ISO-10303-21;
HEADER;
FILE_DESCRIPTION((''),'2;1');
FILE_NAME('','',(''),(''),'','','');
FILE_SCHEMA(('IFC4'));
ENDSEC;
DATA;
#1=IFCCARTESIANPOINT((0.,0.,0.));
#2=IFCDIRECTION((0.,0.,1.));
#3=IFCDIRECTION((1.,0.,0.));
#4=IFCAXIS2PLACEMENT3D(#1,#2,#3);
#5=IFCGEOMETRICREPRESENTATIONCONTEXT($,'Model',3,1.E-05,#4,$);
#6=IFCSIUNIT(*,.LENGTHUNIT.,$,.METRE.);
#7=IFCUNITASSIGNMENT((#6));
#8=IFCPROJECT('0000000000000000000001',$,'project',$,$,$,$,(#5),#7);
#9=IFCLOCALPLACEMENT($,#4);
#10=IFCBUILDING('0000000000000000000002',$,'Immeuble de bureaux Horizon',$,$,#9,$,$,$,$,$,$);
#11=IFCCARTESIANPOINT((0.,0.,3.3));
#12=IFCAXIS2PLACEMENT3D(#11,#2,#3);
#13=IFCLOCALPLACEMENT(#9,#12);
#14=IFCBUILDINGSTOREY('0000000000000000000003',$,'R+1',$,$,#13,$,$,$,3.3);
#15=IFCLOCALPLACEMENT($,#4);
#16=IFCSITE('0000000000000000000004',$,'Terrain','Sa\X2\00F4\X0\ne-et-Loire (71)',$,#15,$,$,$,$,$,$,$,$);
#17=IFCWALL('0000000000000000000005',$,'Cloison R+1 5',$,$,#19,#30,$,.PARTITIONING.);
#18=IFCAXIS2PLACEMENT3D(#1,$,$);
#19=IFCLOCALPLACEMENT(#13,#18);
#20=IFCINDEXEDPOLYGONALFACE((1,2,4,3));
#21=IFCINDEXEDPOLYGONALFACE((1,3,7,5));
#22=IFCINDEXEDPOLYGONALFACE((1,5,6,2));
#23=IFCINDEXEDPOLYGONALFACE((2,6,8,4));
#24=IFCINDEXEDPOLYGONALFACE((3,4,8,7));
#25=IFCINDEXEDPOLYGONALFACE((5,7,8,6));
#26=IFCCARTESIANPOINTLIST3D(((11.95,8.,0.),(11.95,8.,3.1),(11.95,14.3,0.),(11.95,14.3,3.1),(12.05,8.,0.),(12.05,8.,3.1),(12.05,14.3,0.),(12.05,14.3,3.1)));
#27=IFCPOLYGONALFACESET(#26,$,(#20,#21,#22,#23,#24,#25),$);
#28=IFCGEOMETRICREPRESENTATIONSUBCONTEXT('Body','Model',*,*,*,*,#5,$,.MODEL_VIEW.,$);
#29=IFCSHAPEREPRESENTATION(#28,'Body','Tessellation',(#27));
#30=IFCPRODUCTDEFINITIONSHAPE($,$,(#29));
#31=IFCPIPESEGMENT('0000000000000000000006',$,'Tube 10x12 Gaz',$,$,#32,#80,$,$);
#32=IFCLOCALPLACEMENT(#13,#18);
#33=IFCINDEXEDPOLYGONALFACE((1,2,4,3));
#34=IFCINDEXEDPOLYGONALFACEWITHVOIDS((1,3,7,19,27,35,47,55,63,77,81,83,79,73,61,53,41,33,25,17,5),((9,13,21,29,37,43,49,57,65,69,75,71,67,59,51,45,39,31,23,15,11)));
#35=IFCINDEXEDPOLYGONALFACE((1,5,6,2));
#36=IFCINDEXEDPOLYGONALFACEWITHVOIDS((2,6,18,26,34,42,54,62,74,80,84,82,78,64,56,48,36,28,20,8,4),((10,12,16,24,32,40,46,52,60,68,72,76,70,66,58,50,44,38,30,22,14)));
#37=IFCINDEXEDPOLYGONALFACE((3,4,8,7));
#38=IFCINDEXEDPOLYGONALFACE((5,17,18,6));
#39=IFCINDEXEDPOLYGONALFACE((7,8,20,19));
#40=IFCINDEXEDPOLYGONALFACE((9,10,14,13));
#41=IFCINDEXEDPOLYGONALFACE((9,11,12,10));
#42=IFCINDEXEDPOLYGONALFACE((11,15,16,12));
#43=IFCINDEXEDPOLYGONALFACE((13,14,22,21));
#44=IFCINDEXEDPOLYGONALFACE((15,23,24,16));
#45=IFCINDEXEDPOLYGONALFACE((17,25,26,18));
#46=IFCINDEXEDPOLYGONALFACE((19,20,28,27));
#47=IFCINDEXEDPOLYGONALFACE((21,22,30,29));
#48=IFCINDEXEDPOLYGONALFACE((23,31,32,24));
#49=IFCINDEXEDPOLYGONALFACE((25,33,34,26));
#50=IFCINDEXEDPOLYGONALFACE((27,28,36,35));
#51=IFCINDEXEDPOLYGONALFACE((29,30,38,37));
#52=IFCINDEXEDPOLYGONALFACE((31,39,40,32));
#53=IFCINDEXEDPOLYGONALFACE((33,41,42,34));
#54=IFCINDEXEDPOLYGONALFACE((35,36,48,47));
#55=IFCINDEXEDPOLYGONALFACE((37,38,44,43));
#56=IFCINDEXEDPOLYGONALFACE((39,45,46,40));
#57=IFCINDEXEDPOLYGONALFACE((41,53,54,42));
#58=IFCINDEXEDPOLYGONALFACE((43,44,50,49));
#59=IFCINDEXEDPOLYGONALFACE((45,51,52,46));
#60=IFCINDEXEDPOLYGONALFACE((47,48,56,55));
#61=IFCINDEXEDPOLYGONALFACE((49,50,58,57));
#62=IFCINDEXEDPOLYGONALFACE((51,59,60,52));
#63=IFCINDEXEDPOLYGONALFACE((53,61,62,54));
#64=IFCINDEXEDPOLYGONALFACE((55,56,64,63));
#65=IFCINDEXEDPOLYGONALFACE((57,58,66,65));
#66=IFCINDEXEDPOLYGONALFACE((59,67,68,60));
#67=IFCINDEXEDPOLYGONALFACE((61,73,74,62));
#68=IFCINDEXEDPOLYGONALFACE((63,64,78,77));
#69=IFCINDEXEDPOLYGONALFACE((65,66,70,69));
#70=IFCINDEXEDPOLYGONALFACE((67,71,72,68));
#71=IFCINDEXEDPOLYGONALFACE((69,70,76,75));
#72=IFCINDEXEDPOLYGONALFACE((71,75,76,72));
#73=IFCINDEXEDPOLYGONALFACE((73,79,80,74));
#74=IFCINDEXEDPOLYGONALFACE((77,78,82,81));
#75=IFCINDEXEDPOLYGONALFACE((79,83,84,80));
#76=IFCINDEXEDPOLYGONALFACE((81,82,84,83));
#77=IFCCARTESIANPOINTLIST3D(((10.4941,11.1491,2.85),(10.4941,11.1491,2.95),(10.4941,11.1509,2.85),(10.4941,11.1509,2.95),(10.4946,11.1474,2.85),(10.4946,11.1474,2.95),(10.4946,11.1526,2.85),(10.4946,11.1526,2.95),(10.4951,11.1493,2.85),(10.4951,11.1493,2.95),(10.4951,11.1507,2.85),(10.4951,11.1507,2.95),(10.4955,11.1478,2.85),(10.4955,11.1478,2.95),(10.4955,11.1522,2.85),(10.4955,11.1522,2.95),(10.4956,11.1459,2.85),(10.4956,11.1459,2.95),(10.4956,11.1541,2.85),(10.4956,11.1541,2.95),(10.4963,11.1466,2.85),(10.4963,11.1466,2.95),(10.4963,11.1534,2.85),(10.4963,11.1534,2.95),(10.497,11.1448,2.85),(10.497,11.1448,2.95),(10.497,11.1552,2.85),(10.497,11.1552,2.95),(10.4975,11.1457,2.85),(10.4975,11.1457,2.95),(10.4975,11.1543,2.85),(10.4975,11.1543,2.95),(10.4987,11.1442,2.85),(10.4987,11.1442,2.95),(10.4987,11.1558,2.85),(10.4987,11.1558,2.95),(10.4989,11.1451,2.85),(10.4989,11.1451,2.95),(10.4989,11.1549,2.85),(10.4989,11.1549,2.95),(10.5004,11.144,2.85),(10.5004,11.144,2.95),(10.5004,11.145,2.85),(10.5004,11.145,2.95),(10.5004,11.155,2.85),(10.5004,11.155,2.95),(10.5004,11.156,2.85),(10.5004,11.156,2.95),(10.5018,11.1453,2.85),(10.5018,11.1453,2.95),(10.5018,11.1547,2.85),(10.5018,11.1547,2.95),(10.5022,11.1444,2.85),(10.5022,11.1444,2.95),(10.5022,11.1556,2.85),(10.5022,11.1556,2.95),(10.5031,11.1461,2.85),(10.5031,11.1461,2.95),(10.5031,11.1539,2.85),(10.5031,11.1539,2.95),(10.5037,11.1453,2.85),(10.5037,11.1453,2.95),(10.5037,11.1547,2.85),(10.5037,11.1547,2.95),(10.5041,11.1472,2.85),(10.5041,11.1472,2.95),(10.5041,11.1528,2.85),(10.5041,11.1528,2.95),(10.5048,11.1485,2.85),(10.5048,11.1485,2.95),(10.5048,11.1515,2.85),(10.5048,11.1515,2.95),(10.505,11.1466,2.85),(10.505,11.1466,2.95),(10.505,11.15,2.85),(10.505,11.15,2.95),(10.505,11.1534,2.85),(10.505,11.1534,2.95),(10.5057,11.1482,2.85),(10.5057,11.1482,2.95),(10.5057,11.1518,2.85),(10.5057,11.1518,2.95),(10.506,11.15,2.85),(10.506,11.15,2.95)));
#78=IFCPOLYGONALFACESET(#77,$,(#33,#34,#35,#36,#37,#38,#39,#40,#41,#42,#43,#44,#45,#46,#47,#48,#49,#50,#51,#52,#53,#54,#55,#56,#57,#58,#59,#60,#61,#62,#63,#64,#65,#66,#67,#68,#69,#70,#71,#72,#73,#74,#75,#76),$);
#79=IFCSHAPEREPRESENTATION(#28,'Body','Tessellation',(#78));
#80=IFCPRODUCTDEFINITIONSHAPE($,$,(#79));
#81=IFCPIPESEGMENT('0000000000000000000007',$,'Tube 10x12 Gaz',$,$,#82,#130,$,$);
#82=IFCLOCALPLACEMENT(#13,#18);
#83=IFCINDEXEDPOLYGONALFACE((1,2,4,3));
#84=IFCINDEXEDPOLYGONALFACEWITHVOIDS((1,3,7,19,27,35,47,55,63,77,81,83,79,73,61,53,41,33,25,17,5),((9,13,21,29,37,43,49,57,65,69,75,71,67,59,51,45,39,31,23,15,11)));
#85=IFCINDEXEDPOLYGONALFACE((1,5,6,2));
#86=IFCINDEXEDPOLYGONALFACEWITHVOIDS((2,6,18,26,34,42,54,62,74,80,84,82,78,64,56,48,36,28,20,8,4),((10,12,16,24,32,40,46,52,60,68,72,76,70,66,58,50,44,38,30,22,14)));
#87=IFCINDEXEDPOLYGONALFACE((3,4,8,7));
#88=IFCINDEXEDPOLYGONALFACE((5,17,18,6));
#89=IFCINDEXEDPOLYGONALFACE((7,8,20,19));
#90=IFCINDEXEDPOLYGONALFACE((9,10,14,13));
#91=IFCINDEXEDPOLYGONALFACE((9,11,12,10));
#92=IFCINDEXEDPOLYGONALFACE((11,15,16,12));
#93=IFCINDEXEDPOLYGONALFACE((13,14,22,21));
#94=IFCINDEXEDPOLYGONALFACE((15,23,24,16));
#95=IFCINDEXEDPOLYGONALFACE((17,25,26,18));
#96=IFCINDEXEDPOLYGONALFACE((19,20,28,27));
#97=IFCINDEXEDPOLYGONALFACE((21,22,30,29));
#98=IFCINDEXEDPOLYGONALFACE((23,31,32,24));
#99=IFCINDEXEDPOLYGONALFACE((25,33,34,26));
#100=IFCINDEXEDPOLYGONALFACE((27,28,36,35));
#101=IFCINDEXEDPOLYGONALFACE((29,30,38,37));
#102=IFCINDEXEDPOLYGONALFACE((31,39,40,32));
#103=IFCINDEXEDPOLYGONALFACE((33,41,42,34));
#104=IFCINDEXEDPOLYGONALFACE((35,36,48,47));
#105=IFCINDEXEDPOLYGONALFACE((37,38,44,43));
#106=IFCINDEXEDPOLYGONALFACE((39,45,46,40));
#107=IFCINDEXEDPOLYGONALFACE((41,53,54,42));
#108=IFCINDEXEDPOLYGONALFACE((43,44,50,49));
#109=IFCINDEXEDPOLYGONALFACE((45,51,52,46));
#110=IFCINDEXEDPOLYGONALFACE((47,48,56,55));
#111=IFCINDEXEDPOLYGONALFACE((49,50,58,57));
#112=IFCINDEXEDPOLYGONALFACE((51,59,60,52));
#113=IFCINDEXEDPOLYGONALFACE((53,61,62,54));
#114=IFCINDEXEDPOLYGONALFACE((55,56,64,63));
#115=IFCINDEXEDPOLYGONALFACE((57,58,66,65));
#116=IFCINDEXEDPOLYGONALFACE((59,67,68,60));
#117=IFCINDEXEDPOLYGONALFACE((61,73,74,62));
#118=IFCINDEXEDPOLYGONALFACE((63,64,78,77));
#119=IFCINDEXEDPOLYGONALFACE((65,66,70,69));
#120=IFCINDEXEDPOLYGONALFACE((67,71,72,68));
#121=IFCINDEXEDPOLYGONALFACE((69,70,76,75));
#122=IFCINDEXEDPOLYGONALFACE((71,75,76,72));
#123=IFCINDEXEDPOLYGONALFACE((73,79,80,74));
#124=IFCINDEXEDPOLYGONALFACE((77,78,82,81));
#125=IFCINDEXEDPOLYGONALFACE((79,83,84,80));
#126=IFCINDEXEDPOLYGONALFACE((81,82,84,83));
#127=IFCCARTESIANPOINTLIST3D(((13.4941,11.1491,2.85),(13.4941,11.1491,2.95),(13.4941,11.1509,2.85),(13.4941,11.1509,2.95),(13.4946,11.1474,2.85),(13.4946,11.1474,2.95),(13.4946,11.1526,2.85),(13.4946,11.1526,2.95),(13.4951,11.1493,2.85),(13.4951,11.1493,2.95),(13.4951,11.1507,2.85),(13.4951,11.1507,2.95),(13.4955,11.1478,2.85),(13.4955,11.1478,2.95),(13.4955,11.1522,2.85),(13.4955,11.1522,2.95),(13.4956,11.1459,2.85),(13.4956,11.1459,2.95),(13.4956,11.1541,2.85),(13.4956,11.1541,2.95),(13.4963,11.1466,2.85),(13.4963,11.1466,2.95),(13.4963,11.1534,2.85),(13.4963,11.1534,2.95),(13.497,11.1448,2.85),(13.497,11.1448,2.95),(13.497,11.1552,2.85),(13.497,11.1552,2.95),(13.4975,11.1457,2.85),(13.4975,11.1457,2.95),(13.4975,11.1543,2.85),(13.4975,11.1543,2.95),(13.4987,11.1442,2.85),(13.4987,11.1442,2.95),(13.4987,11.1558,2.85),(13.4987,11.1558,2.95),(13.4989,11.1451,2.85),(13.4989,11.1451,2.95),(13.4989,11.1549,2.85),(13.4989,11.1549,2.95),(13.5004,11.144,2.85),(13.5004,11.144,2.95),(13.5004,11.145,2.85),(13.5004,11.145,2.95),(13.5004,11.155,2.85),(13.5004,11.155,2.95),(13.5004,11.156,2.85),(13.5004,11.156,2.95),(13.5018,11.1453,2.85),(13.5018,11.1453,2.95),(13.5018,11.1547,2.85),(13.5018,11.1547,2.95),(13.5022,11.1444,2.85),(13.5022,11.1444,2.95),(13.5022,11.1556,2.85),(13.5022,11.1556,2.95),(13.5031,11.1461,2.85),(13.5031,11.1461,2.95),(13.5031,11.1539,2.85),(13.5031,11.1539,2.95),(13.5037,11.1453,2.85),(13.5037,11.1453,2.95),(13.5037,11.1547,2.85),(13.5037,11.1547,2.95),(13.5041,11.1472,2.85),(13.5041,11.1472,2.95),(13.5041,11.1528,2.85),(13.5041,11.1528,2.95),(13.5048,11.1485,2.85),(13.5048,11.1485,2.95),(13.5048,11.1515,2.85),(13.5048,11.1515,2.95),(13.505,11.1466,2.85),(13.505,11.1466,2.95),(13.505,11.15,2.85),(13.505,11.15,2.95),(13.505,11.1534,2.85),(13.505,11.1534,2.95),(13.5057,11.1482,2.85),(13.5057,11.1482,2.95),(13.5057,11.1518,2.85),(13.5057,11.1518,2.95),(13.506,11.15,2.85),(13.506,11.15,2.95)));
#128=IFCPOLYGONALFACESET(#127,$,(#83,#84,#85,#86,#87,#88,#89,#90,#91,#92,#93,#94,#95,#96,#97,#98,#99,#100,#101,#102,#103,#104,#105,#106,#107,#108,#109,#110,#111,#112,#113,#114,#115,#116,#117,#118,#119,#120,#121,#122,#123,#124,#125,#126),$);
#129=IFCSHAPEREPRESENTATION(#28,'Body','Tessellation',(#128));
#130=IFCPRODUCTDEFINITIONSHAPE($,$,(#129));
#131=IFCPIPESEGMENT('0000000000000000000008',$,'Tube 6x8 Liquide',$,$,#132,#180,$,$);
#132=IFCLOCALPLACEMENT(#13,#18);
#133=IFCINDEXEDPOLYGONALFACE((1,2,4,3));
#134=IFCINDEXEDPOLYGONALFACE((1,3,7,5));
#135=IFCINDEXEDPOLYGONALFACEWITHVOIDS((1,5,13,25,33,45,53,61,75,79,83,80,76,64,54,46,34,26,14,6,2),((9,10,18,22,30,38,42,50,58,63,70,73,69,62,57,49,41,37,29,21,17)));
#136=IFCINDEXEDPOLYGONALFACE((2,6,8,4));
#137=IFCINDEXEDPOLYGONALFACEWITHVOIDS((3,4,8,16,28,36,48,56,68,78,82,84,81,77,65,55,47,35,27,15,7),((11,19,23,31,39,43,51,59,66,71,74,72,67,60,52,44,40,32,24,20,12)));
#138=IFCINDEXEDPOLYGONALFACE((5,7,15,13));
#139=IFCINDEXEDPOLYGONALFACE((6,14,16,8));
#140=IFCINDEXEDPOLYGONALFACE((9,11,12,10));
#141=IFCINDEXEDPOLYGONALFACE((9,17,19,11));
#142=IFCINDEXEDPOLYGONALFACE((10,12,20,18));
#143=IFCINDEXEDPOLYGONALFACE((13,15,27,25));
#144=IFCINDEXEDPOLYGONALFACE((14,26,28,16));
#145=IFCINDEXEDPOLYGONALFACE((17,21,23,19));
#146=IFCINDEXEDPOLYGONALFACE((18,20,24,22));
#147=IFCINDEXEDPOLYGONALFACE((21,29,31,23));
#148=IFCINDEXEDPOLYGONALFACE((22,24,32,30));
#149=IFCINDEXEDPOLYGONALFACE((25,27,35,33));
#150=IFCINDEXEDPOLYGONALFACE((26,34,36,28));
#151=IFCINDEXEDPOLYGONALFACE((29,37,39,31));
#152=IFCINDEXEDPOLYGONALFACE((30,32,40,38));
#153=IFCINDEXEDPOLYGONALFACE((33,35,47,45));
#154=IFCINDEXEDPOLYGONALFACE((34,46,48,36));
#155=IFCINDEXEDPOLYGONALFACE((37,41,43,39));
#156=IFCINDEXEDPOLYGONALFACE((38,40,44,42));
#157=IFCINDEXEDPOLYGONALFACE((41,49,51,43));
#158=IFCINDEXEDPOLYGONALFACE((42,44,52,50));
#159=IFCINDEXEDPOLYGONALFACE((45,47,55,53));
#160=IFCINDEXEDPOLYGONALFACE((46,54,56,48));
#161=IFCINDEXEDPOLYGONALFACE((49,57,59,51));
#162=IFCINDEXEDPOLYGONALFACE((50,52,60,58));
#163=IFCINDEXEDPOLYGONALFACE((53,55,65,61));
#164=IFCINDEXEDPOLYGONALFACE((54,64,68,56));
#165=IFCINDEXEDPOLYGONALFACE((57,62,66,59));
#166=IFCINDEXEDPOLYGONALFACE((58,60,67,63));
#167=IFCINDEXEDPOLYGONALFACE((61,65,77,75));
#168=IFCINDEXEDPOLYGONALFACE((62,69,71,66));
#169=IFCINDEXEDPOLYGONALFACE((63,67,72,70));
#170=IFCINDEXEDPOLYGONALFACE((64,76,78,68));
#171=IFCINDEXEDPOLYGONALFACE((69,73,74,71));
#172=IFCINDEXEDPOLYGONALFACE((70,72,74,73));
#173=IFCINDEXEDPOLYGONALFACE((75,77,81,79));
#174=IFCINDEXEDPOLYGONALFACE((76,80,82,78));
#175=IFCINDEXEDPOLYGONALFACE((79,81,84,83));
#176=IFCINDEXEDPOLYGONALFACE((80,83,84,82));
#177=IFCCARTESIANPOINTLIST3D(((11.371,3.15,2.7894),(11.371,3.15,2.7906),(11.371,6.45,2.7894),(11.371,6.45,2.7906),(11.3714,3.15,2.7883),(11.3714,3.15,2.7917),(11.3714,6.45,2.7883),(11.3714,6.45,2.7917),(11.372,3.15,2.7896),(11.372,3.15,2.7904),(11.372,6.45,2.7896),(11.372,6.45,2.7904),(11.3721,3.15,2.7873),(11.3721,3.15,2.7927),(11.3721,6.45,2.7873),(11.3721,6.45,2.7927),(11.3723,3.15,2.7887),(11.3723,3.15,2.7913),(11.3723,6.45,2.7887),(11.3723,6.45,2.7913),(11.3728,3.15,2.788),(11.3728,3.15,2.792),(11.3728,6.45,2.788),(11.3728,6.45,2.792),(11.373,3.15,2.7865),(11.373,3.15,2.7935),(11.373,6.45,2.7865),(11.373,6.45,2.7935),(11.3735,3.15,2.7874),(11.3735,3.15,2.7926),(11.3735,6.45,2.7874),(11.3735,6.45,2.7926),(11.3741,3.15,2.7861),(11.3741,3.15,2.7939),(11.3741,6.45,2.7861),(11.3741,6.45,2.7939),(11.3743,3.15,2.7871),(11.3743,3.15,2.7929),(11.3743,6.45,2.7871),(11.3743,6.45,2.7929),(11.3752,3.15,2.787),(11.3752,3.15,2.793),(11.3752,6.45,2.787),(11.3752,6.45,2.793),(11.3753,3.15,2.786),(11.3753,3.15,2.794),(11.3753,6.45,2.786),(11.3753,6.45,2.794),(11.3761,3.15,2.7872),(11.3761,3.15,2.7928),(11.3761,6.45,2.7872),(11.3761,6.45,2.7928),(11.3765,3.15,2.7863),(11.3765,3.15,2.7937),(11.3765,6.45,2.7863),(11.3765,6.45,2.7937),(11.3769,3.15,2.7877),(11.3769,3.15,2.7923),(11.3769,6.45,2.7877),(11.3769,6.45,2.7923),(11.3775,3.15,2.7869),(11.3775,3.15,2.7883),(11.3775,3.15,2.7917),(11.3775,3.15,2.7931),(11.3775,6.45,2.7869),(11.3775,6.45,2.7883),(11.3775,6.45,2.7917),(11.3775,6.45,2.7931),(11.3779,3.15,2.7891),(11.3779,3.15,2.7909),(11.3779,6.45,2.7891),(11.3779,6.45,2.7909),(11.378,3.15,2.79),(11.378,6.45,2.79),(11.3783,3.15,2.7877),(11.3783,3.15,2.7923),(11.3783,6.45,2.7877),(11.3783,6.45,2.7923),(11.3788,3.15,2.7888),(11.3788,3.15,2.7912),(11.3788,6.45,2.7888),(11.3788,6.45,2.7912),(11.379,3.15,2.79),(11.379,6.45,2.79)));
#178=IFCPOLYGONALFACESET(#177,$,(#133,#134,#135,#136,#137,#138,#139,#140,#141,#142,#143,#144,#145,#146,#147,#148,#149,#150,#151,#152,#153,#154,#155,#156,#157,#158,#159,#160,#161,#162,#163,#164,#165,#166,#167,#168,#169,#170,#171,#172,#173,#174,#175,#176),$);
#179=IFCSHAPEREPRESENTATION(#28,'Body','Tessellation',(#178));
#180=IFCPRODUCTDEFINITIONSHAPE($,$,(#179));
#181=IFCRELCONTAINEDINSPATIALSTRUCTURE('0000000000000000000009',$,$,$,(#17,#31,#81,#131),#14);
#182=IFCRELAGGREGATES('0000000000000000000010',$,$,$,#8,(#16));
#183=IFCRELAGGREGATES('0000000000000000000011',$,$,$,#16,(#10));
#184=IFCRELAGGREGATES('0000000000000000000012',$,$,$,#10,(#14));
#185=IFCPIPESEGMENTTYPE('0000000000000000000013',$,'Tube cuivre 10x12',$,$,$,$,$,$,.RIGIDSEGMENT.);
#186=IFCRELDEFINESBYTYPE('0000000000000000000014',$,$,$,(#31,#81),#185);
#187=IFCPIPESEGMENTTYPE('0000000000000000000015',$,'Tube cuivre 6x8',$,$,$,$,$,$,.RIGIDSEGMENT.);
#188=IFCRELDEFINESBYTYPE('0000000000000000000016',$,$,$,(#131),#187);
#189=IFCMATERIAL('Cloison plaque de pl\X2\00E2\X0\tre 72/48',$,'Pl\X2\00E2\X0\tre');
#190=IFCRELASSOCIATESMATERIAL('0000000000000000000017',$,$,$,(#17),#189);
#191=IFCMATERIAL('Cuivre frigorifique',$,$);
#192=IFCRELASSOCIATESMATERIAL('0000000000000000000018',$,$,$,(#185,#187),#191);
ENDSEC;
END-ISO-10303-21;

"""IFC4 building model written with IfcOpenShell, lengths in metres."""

from ifc_helpers import new_model, si_unit, frame, frame_2d, origin_with_axes, place, context, subcontext, project, spatial, rectangle, hollow_circle, extrude, material, type_object, element, save


model = new_model("IFC4")

# Units and contexts
model_context = context("Model", 3, precision=1e-05, world=origin_with_axes())
body_context = subcontext(model_context, "Body", "Model", "MODEL_VIEW")
ifc_project = project(units=[si_unit("LENGTHUNIT", "METRE")], contexts=[model_context])

# Site, building, storey
site_placement = place(None, origin_with_axes())
site = spatial("IfcSite", under=ifc_project, at=site_placement, Name="Terrain", Description="Saône-et-Loire (71)")
building_placement = place(None, origin_with_axes())
building = spatial("IfcBuilding", under=site, at=building_placement, Name="Immeuble de bureaux Horizon")
storey_placement = place(building_placement, frame((0.0, 0.0, 3.3), z_axis=(0.0, 0.0, 1.0), x_axis=(1.0, 0.0, 0.0)))
storey = spatial("IfcBuildingStorey", under=building, at=storey_placement, Name="R+1", Elevation=3.3)

# Wall
ifc_material_1 = material(Name="Cloison plaque de plâtre 72/48", Category="Plâtre")
wall_placement = place(storey_placement, frame((11.95, 8.0, 0.0), z_axis=(0.0, 0.0, 1.0), x_axis=(1.0, 0.0, 0.0)))
element("IfcWall", 1, at=wall_placement, inside=storey, material=ifc_material_1, Name="Cloison R+1 5", PredefinedType="PARTITIONING", context=body_context, shape_type="SweptSolid", body=[
    extrude(rectangle(XDim=0.1, YDim=6.3, at=frame_2d((0.05, 3.15))), origin_with_axes(), (0.0, 0.0, 1.0), 3.1),
])

# Pipe segments
ifc_material_2 = material(Name="Cuivre frigorifique")
pipe_segment_type_1 = type_object("IfcPipeSegmentType", Name="Tube cuivre 10x12", PredefinedType="RIGIDSEGMENT", material=ifc_material_2)
for number, where, z_axis, x_axis, name in (
    (2, (10.5, 11.15, 2.85), (0.0, 0.0, 1.0), (1.0, 0.0, 0.0), "Tube 10x12 Gaz"),
    (3, (13.5, 11.15, 2.85), (0.0, 0.0, 1.0), (1.0, 0.0, 0.0), "Tube 10x12 Gaz"),
):
    element("IfcPipeSegment", number, at=place(storey_placement, frame(where, z_axis=z_axis, x_axis=x_axis)), inside=storey, type_object=pipe_segment_type_1, Name=name, context=body_context, shape_type="SweptSolid", body=[
        extrude(hollow_circle(Radius=0.006, WallThickness=0.001), origin_with_axes(), (0.0, 0.0, 1.0), 0.1),
    ])
pipe_segment_type_2 = type_object("IfcPipeSegmentType", Name="Tube cuivre 6x8", PredefinedType="RIGIDSEGMENT", material=ifc_material_2)
pipe_segment_1_placement = place(storey_placement, frame((11.375, 6.45, 2.79), z_axis=(0.0, -1.0, 0.0), x_axis=(1.0, 0.0, 0.0)))
element("IfcPipeSegment", 4, at=pipe_segment_1_placement, inside=storey, type_object=pipe_segment_type_2, Name="Tube 6x8 Liquide", context=body_context, shape_type="SweptSolid", body=[
    extrude(hollow_circle(Radius=0.004, WallThickness=0.001), origin_with_axes(), (0.0, 0.0, 1.0), 3.3),
])

save(model, "model.ifc")
